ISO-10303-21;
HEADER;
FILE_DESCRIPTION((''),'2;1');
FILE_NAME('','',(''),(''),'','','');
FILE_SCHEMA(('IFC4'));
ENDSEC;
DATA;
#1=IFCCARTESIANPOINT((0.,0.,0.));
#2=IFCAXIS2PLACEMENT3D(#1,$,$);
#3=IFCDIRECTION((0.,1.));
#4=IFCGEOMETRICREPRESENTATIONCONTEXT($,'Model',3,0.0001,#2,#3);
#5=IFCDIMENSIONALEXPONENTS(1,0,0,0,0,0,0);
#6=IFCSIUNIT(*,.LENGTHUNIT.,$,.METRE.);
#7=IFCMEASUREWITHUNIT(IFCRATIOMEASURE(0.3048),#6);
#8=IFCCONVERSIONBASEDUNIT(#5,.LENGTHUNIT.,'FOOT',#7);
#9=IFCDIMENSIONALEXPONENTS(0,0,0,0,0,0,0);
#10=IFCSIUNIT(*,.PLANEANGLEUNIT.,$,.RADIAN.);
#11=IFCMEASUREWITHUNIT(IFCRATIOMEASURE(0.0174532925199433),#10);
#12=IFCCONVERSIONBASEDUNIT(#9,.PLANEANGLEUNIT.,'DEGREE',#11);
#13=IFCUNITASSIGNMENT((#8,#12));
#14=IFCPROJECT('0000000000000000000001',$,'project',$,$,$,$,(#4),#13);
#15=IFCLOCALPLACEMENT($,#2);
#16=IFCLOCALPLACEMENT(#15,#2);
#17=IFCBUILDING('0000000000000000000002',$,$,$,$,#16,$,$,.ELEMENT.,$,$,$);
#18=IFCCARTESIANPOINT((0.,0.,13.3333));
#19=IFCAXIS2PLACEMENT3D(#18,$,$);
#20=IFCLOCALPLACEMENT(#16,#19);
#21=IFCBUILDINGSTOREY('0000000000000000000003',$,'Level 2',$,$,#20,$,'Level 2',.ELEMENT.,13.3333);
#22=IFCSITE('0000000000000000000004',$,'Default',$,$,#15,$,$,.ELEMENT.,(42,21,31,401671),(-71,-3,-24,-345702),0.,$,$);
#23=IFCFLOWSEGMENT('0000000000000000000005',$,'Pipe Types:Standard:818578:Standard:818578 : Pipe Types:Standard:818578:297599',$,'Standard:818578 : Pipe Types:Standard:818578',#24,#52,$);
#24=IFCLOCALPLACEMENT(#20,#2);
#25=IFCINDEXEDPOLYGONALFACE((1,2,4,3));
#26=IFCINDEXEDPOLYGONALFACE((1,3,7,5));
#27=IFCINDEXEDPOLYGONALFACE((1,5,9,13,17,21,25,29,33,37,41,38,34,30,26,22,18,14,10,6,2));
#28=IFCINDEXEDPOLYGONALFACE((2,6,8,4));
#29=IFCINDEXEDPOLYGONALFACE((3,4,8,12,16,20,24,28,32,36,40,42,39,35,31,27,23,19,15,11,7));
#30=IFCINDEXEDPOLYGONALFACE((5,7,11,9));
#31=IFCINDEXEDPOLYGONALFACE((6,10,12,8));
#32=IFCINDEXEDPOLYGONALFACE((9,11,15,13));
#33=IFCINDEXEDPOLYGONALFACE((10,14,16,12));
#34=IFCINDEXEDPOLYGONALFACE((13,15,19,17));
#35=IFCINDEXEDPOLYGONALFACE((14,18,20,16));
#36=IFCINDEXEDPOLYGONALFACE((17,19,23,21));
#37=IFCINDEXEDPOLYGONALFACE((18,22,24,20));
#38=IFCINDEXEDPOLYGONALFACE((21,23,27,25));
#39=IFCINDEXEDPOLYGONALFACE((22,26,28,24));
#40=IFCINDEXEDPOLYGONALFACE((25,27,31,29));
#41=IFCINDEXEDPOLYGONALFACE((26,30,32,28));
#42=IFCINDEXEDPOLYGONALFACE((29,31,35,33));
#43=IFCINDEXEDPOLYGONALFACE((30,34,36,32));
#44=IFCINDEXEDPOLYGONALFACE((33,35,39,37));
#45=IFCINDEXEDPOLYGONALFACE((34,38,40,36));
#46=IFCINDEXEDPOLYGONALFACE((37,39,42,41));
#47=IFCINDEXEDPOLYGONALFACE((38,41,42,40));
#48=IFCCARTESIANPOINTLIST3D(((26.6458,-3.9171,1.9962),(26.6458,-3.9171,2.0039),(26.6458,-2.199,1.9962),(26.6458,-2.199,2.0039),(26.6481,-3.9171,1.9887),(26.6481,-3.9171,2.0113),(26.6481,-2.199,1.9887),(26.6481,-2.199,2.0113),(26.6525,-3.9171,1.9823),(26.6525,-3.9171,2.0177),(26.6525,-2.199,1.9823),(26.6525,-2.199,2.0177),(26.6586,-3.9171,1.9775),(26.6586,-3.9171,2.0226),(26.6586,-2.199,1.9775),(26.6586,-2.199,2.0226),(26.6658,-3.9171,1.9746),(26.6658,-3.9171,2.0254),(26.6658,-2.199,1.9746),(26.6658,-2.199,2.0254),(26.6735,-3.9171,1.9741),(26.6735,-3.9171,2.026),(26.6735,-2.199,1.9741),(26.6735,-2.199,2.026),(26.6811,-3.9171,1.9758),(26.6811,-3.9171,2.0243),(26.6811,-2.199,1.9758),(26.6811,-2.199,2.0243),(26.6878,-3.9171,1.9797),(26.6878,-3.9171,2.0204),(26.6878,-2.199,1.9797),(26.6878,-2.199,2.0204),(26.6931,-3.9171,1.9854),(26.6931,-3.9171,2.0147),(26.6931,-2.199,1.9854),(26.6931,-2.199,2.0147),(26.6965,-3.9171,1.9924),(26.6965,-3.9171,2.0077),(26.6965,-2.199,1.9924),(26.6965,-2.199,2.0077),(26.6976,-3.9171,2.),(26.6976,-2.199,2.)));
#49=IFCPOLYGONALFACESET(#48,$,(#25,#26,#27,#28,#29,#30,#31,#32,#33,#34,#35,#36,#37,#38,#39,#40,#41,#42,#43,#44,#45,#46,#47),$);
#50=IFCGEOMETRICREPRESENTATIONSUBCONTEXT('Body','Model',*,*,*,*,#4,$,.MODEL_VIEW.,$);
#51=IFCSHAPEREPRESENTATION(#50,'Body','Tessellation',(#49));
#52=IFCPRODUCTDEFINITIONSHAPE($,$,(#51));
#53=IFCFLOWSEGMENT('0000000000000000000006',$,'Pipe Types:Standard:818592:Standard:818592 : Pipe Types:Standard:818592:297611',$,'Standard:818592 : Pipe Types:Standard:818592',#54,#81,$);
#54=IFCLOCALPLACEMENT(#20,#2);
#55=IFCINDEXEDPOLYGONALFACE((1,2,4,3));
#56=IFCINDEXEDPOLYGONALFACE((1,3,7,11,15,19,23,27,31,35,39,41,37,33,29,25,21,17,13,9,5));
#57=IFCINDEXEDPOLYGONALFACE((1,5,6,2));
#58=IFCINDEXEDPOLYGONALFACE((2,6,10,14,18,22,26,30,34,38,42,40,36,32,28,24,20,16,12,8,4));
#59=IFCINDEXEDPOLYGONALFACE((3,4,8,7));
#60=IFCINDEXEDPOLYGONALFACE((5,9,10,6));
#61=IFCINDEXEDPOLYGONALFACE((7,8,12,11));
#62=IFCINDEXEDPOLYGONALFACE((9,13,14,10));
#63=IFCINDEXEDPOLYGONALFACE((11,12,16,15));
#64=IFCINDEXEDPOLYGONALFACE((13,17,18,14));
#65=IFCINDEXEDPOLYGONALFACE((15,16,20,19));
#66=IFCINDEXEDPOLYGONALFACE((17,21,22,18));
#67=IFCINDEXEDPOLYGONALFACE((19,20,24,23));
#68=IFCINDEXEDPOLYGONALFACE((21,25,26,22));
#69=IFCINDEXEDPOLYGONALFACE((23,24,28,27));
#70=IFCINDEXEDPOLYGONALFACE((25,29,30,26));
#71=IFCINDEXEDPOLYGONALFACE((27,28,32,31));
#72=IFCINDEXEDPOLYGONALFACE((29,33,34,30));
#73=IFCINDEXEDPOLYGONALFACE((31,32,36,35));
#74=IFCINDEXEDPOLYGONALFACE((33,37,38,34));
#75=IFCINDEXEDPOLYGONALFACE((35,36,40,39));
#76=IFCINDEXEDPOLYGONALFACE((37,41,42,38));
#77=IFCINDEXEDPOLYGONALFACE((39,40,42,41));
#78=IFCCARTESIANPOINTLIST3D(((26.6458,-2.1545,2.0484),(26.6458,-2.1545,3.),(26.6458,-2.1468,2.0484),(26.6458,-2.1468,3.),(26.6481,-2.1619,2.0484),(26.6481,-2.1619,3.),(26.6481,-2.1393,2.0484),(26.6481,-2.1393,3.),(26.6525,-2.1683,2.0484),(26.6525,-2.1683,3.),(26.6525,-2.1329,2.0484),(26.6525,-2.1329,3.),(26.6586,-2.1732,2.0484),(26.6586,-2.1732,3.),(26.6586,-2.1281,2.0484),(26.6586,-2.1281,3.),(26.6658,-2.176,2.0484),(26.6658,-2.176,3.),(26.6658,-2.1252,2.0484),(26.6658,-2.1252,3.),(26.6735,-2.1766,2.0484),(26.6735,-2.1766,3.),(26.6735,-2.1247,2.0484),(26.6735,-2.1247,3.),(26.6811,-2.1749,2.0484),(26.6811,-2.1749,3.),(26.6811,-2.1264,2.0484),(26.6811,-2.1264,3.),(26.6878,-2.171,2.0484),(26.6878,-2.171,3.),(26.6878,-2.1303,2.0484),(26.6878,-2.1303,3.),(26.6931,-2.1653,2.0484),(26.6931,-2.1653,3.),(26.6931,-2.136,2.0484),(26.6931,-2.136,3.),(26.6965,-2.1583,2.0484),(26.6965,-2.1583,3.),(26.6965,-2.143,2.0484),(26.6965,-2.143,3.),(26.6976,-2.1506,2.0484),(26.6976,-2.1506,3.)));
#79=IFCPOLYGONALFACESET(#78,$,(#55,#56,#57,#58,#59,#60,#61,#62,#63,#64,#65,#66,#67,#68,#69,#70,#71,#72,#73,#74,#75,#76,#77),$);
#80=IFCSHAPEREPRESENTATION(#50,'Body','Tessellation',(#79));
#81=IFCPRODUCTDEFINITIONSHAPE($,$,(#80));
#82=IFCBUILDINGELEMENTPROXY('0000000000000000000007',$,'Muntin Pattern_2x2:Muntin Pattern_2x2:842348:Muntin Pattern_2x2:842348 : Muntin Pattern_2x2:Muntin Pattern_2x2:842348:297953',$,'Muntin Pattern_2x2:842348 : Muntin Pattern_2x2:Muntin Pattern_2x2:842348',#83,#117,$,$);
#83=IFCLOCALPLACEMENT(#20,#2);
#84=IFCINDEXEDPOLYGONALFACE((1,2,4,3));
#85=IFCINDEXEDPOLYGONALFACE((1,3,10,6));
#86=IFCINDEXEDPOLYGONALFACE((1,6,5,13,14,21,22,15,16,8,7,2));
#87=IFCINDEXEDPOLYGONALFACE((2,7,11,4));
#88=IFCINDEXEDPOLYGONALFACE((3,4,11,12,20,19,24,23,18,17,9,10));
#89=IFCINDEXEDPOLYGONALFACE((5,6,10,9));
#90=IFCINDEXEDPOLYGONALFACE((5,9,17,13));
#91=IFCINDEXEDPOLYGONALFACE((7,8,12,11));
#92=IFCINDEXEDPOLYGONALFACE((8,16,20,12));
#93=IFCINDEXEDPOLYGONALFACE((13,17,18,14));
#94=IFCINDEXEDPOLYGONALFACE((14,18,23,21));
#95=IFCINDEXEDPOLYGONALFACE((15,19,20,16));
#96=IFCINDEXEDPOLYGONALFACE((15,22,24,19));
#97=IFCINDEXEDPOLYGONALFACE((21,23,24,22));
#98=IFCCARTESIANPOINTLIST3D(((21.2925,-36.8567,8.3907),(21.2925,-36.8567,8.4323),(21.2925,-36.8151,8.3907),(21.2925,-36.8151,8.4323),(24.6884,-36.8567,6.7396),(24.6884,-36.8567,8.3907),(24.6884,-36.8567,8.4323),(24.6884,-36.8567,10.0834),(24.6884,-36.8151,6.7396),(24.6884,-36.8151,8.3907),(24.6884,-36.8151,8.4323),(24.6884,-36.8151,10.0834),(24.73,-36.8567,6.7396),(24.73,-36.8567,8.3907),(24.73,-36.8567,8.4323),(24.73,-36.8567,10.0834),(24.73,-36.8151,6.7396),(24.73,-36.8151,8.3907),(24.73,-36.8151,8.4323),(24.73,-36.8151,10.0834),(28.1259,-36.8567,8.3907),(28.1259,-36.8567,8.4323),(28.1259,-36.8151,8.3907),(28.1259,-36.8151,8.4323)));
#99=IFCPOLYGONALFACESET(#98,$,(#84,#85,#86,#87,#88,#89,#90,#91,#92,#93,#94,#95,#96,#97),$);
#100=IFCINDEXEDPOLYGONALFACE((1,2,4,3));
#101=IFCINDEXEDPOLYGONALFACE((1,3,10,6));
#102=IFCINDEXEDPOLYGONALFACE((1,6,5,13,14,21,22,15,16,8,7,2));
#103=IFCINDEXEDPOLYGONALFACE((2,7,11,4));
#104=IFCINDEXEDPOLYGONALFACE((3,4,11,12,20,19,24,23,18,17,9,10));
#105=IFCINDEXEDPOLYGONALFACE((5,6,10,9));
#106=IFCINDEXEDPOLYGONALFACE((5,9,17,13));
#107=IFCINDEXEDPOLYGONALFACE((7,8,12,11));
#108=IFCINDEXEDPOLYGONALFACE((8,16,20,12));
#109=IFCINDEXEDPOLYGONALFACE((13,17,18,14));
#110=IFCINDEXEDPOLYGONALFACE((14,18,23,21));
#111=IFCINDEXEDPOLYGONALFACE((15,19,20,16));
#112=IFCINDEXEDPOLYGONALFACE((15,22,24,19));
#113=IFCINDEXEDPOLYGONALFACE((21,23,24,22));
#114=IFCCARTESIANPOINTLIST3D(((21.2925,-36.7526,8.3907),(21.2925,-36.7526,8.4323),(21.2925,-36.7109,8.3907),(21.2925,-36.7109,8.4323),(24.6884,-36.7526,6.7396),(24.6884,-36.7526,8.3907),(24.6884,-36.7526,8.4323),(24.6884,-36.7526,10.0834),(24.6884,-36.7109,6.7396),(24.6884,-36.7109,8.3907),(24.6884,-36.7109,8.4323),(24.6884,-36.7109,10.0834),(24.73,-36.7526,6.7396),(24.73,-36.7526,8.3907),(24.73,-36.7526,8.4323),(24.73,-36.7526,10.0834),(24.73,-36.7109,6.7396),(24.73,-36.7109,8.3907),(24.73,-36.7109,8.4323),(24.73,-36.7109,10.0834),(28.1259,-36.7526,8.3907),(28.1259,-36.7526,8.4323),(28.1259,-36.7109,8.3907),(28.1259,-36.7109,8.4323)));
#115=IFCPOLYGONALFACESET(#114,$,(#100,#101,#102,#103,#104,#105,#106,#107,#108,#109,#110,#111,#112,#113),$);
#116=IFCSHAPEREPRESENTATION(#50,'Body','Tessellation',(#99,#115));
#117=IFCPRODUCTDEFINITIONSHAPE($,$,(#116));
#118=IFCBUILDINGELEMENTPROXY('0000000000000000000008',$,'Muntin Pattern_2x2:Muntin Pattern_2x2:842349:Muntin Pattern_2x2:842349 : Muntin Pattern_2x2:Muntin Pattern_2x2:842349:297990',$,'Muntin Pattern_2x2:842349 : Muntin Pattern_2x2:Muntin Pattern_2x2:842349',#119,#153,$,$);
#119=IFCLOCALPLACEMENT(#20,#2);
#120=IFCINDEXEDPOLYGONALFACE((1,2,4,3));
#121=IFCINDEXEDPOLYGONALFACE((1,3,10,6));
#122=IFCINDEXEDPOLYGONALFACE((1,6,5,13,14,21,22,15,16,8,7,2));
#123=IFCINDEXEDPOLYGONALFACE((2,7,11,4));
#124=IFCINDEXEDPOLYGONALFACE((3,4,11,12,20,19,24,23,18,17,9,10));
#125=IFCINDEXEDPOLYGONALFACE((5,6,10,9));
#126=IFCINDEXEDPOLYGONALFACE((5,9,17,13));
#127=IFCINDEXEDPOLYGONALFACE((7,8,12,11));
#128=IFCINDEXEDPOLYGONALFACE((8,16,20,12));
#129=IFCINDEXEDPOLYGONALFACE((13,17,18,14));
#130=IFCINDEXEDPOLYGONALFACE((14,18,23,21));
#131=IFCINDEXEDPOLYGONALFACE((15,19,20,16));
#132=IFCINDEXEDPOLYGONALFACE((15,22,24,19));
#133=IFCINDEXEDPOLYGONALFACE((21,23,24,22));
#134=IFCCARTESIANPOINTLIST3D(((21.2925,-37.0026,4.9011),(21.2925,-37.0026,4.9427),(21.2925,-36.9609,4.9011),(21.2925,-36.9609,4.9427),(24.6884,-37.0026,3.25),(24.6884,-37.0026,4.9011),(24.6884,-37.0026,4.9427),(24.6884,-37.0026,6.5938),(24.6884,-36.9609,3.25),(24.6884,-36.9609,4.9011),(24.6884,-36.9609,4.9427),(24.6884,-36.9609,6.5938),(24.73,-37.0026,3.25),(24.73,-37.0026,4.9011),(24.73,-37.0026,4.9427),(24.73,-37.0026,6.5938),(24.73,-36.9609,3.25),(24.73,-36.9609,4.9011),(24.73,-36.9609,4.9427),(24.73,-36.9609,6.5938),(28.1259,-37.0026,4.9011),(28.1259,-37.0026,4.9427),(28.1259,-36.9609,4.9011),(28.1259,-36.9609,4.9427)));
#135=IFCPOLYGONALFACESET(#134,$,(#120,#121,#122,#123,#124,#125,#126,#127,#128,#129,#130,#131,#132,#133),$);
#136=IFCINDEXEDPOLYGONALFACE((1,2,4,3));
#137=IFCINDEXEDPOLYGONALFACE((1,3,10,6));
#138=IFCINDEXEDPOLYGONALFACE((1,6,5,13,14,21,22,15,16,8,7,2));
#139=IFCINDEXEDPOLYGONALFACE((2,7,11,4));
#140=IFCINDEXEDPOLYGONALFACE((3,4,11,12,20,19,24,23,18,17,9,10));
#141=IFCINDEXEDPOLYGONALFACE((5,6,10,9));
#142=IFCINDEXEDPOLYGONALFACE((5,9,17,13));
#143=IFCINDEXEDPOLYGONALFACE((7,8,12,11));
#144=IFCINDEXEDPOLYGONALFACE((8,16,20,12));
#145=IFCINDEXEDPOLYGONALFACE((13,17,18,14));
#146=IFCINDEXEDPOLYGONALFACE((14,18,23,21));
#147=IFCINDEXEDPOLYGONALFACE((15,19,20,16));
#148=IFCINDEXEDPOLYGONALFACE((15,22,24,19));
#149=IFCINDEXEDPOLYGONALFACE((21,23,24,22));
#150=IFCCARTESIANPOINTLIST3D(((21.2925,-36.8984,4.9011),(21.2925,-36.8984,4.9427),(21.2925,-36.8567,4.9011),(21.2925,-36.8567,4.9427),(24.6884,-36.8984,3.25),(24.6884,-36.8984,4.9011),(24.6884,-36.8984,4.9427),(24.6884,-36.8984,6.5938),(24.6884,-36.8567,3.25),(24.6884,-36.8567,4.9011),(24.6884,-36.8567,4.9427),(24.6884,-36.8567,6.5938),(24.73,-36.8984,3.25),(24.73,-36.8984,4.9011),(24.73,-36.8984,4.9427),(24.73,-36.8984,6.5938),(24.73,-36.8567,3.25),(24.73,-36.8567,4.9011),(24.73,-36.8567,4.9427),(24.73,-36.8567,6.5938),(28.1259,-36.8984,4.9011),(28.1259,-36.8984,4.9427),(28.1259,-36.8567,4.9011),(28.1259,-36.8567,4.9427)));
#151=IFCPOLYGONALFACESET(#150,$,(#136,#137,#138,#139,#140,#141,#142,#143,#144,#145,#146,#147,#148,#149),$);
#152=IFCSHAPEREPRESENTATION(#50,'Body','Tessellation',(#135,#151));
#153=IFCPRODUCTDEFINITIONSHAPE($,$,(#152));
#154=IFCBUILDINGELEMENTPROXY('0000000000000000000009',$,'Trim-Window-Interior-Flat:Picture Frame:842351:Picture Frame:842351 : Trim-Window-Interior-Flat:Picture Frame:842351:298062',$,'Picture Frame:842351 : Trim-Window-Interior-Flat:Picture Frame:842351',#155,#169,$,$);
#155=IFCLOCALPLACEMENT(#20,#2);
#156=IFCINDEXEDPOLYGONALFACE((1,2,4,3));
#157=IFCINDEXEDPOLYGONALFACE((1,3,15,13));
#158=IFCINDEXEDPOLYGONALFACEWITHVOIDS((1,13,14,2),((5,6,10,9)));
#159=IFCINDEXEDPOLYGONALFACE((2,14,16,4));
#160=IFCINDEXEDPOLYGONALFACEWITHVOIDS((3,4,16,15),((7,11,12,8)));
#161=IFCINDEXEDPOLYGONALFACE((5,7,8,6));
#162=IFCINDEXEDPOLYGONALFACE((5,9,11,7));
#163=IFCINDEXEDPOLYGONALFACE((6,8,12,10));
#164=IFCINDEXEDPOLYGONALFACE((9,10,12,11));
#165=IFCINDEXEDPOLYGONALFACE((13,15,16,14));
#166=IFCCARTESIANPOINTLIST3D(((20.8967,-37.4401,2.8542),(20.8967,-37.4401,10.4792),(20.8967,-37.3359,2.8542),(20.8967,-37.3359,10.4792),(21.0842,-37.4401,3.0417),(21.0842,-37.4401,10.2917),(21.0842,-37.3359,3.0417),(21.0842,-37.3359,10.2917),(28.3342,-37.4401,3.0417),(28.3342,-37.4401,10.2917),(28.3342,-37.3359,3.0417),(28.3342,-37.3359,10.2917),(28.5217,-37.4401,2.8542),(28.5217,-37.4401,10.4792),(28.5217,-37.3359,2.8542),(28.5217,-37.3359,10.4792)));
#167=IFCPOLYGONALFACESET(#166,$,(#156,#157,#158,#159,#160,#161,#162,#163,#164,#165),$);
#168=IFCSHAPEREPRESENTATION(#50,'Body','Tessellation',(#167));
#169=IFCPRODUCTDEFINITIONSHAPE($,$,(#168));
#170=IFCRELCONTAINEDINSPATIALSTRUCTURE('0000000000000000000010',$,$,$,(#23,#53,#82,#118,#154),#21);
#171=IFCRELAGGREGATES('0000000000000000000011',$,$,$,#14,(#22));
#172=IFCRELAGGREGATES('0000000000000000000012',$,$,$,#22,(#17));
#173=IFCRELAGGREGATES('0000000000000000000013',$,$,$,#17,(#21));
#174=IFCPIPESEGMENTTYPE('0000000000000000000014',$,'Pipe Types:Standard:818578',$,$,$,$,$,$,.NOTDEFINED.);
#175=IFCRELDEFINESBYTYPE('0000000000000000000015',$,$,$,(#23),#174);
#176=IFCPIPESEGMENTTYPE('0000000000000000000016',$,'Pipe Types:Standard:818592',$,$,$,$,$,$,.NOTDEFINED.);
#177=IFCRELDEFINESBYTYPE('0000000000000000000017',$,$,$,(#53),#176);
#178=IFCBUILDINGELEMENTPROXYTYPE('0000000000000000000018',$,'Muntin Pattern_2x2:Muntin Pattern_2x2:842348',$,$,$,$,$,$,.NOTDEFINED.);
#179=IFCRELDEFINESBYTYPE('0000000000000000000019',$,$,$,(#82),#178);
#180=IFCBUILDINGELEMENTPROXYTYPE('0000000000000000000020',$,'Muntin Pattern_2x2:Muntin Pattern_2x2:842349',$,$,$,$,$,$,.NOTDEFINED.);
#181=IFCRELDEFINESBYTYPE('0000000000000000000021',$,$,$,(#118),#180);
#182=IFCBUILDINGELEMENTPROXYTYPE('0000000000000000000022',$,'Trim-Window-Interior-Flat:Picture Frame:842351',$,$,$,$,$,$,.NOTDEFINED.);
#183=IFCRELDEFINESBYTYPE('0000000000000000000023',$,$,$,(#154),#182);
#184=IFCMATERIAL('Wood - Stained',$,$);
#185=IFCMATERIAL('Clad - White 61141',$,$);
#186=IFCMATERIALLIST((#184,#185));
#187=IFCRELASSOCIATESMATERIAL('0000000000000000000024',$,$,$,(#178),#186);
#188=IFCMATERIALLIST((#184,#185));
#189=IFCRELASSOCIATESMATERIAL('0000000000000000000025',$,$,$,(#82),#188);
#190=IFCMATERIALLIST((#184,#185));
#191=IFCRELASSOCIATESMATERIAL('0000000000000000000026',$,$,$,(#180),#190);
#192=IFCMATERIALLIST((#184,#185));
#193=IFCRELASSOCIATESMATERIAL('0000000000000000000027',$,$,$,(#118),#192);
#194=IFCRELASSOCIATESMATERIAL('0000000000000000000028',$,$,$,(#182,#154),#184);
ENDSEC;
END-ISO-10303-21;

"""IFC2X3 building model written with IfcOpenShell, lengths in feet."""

from ifc_helpers import new_model, entity, si_unit, converted_unit, direction, frame, origin, origin_2d_with_axis, place, context, subcontext, project, spatial, polyline, circle, outline, extrude, source, transform, mapped, material, material_list, type_object, type_shapes, element, save


model = new_model("IFC2X3")

# Units and contexts
model_context = context("Model", 3, precision=0.0001, world=origin(), true_north=direction((0.0, 1.0)))
body_context = subcontext(model_context, "Body", "Model", "MODEL_VIEW")
ifc_project = project(units=[converted_unit("LENGTHUNIT", "FOOT", entity("IfcRatioMeasure", 0.3048), si_unit("LENGTHUNIT", "METRE"), dimensions=[1, 0, 0, 0, 0, 0, 0]), converted_unit("PLANEANGLEUNIT", "DEGREE", entity("IfcRatioMeasure", 0.0174532925199433), si_unit("PLANEANGLEUNIT", "RADIAN"), dimensions=[0, 0, 0, 0, 0, 0, 0])], contexts=[model_context])

# Site, building, storey
site_placement = place(None, origin())
site = spatial("IfcSite", under=ifc_project, at=site_placement, Name="Default", CompositionType="ELEMENT", RefLatitude=(42, 21, 31, 401671), RefLongitude=(-71, -3, -24, -345702), RefElevation=0.0)
building_placement = place(site_placement, origin())
building = spatial("IfcBuilding", under=site, at=building_placement, CompositionType="ELEMENT")
storey_placement = place(building_placement, frame((0.0, 0.0, 13.3333)))
storey = spatial("IfcBuildingStorey", under=building, at=storey_placement, Name="Level 2", LongName="Level 2", CompositionType="ELEMENT", Elevation=13.3333)

# Flow segments
pipe_segment_type_1 = type_object("IfcPipeSegmentType", Name="Pipe Types:Standard:818578", PredefinedType="NOTDEFINED")
shared_shape_1 = source(origin(), body_context, "Body", "SweptSolid", [
    extrude(circle(Radius=0.026, at=origin_2d_with_axis()), frame((26.6716, -3.9171, 15.3333), z_axis=(0.0, 1.0, 0.0), x_axis=(1.0, 0.0, 0.0)), (0.0, 0.0, 1.0), 1.7181),
])
type_shapes(pipe_segment_type_1, [shared_shape_1])
flow_segment_1_placement = place(building_placement, origin())
element("IfcFlowSegment", 1, at=flow_segment_1_placement, inside=storey, type_object=pipe_segment_type_1, Name="Pipe Types:Standard:818578:Standard:818578 : Pipe Types:Standard:818578:297599", ObjectType="Standard:818578 : Pipe Types:Standard:818578", context=body_context, shape_type="MappedRepresentation", body=[
    mapped(shared_shape_1, transform((0.0, 0.0, 0.0), scale=1.0)),
])
pipe_segment_type_2 = type_object("IfcPipeSegmentType", Name="Pipe Types:Standard:818592", PredefinedType="NOTDEFINED")
shared_shape_2 = source(origin(), body_context, "Body", "SweptSolid", [
    extrude(circle(Radius=0.026, at=origin_2d_with_axis()), frame((26.6716, -2.1506, 15.3817)), (0.0, 0.0, 1.0), 0.9517),
])
type_shapes(pipe_segment_type_2, [shared_shape_2])
flow_segment_2_placement = place(building_placement, origin())
element("IfcFlowSegment", 2, at=flow_segment_2_placement, inside=storey, type_object=pipe_segment_type_2, Name="Pipe Types:Standard:818592:Standard:818592 : Pipe Types:Standard:818592:297611", ObjectType="Standard:818592 : Pipe Types:Standard:818592", context=body_context, shape_type="MappedRepresentation", body=[
    mapped(shared_shape_2, transform((0.0, 0.0, 0.0), scale=1.0)),
])

# Building element proxies
ifc_material_1 = material(Name="Wood - Stained")
ifc_material_2 = material(Name="Clad - White 61141")
ifc_material_list_1 = material_list([ifc_material_1, ifc_material_2])
ifc_material_list_2 = material_list([ifc_material_1, ifc_material_2])
building_element_proxy_type_1 = type_object("IfcBuildingElementProxyType", Name="Muntin Pattern_2x2:Muntin Pattern_2x2:842348", PredefinedType="NOTDEFINED", material=ifc_material_list_2)
shared_shape_3 = source(origin(), body_context, "Body", "SweptSolid", [
    extrude(outline(polyline([(-0.0208, -1.6719), (0.0208, -1.6719), (0.0208, -0.0208), (3.4167, -0.0208), (3.4167, 0.0208), (0.0208, 0.0208), (0.0208, 1.6719), (-0.0208, 1.6719), (-0.0208, 0.0208), (-3.4167, 0.0208), (-3.4167, -0.0208), (-0.0208, -0.0208), (-0.0208, -1.6719)])), frame((24.7092, -36.8567, 21.7448), z_axis=(0.0, 1.0, 0.0), x_axis=(1.0, 0.0, 0.0)), (0.0, 0.0, 1.0), 0.0417),
    extrude(outline(polyline([(-0.0208, -1.6719), (0.0208, -1.6719), (0.0208, -0.0208), (3.4167, -0.0208), (3.4167, 0.0208), (0.0208, 0.0208), (0.0208, 1.6719), (-0.0208, 1.6719), (-0.0208, 0.0208), (-3.4167, 0.0208), (-3.4167, -0.0208), (-0.0208, -0.0208), (-0.0208, -1.6719)])), frame((24.7092, -36.7526, 21.7448), z_axis=(0.0, 1.0, 0.0), x_axis=(1.0, 0.0, 0.0)), (0.0, 0.0, 1.0), 0.0417),
])
type_shapes(building_element_proxy_type_1, [shared_shape_3])
proxy_1_placement = place(building_placement, origin())
element("IfcBuildingElementProxy", 3, at=proxy_1_placement, inside=storey, type_object=building_element_proxy_type_1, material=ifc_material_list_1, Name="Muntin Pattern_2x2:Muntin Pattern_2x2:842348:Muntin Pattern_2x2:842348 : Muntin Pattern_2x2:Muntin Pattern_2x2:842348:297953", ObjectType="Muntin Pattern_2x2:842348 : Muntin Pattern_2x2:Muntin Pattern_2x2:842348", context=body_context, shape_type="MappedRepresentation", body=[
    mapped(shared_shape_3, transform((0.0, 0.0, 0.0), scale=1.0)),
])
ifc_material_list_3 = material_list([ifc_material_1, ifc_material_2])
ifc_material_list_4 = material_list([ifc_material_1, ifc_material_2])
building_element_proxy_type_2 = type_object("IfcBuildingElementProxyType", Name="Muntin Pattern_2x2:Muntin Pattern_2x2:842349", PredefinedType="NOTDEFINED", material=ifc_material_list_4)
shared_shape_4 = source(origin(), body_context, "Body", "SweptSolid", [
    extrude(outline(polyline([(-0.0208, -1.6719), (0.0208, -1.6719), (0.0208, -0.0208), (3.4167, -0.0208), (3.4167, 0.0208), (0.0208, 0.0208), (0.0208, 1.6719), (-0.0208, 1.6719), (-0.0208, 0.0208), (-3.4167, 0.0208), (-3.4167, -0.0208), (-0.0208, -0.0208), (-0.0208, -1.6719)])), frame((24.7092, -37.0026, 18.2552), z_axis=(0.0, 1.0, 0.0), x_axis=(1.0, 0.0, 0.0)), (0.0, 0.0, 1.0), 0.0417),
    extrude(outline(polyline([(-0.0208, -1.6719), (0.0208, -1.6719), (0.0208, -0.0208), (3.4167, -0.0208), (3.4167, 0.0208), (0.0208, 0.0208), (0.0208, 1.6719), (-0.0208, 1.6719), (-0.0208, 0.0208), (-3.4167, 0.0208), (-3.4167, -0.0208), (-0.0208, -0.0208), (-0.0208, -1.6719)])), frame((24.7092, -36.8984, 18.2552), z_axis=(0.0, 1.0, 0.0), x_axis=(1.0, 0.0, 0.0)), (0.0, 0.0, 1.0), 0.0417),
])
type_shapes(building_element_proxy_type_2, [shared_shape_4])
proxy_2_placement = place(building_placement, origin())
element("IfcBuildingElementProxy", 4, at=proxy_2_placement, inside=storey, type_object=building_element_proxy_type_2, material=ifc_material_list_3, Name="Muntin Pattern_2x2:Muntin Pattern_2x2:842349:Muntin Pattern_2x2:842349 : Muntin Pattern_2x2:Muntin Pattern_2x2:842349:297990", ObjectType="Muntin Pattern_2x2:842349 : Muntin Pattern_2x2:Muntin Pattern_2x2:842349", context=body_context, shape_type="MappedRepresentation", body=[
    mapped(shared_shape_4, transform((0.0, 0.0, 0.0), scale=1.0)),
])
building_element_proxy_type_3 = type_object("IfcBuildingElementProxyType", Name="Trim-Window-Interior-Flat:Picture Frame:842351", PredefinedType="NOTDEFINED", material=ifc_material_1)
shared_shape_5 = source(origin(), body_context, "Body", "SweptSolid", [
    extrude(outline(polyline([(-3.8125, -3.8125), (3.8125, -3.8125), (3.8125, 3.8125), (-3.8125, 3.8125), (-3.8125, -3.8125)]), holes=[polyline([(3.625, 3.625), (3.625, -3.625), (-3.625, -3.625), (-3.625, 3.625), (3.625, 3.625)])]), frame((24.7092, -37.4401, 20.0), z_axis=(0.0, 1.0, 0.0), x_axis=(1.0, 0.0, 0.0)), (0.0, 0.0, 1.0), 0.1042),
])
type_shapes(building_element_proxy_type_3, [shared_shape_5])
proxy_3_placement = place(building_placement, origin())
element("IfcBuildingElementProxy", 5, at=proxy_3_placement, inside=storey, type_object=building_element_proxy_type_3, material=ifc_material_1, Name="Trim-Window-Interior-Flat:Picture Frame:842351:Picture Frame:842351 : Trim-Window-Interior-Flat:Picture Frame:842351:298062", ObjectType="Picture Frame:842351 : Trim-Window-Interior-Flat:Picture Frame:842351", context=body_context, shape_type="MappedRepresentation", body=[
    mapped(shared_shape_5, transform((0.0, 0.0, 0.0), scale=1.0)),
])

save(model, "model.ifc")
